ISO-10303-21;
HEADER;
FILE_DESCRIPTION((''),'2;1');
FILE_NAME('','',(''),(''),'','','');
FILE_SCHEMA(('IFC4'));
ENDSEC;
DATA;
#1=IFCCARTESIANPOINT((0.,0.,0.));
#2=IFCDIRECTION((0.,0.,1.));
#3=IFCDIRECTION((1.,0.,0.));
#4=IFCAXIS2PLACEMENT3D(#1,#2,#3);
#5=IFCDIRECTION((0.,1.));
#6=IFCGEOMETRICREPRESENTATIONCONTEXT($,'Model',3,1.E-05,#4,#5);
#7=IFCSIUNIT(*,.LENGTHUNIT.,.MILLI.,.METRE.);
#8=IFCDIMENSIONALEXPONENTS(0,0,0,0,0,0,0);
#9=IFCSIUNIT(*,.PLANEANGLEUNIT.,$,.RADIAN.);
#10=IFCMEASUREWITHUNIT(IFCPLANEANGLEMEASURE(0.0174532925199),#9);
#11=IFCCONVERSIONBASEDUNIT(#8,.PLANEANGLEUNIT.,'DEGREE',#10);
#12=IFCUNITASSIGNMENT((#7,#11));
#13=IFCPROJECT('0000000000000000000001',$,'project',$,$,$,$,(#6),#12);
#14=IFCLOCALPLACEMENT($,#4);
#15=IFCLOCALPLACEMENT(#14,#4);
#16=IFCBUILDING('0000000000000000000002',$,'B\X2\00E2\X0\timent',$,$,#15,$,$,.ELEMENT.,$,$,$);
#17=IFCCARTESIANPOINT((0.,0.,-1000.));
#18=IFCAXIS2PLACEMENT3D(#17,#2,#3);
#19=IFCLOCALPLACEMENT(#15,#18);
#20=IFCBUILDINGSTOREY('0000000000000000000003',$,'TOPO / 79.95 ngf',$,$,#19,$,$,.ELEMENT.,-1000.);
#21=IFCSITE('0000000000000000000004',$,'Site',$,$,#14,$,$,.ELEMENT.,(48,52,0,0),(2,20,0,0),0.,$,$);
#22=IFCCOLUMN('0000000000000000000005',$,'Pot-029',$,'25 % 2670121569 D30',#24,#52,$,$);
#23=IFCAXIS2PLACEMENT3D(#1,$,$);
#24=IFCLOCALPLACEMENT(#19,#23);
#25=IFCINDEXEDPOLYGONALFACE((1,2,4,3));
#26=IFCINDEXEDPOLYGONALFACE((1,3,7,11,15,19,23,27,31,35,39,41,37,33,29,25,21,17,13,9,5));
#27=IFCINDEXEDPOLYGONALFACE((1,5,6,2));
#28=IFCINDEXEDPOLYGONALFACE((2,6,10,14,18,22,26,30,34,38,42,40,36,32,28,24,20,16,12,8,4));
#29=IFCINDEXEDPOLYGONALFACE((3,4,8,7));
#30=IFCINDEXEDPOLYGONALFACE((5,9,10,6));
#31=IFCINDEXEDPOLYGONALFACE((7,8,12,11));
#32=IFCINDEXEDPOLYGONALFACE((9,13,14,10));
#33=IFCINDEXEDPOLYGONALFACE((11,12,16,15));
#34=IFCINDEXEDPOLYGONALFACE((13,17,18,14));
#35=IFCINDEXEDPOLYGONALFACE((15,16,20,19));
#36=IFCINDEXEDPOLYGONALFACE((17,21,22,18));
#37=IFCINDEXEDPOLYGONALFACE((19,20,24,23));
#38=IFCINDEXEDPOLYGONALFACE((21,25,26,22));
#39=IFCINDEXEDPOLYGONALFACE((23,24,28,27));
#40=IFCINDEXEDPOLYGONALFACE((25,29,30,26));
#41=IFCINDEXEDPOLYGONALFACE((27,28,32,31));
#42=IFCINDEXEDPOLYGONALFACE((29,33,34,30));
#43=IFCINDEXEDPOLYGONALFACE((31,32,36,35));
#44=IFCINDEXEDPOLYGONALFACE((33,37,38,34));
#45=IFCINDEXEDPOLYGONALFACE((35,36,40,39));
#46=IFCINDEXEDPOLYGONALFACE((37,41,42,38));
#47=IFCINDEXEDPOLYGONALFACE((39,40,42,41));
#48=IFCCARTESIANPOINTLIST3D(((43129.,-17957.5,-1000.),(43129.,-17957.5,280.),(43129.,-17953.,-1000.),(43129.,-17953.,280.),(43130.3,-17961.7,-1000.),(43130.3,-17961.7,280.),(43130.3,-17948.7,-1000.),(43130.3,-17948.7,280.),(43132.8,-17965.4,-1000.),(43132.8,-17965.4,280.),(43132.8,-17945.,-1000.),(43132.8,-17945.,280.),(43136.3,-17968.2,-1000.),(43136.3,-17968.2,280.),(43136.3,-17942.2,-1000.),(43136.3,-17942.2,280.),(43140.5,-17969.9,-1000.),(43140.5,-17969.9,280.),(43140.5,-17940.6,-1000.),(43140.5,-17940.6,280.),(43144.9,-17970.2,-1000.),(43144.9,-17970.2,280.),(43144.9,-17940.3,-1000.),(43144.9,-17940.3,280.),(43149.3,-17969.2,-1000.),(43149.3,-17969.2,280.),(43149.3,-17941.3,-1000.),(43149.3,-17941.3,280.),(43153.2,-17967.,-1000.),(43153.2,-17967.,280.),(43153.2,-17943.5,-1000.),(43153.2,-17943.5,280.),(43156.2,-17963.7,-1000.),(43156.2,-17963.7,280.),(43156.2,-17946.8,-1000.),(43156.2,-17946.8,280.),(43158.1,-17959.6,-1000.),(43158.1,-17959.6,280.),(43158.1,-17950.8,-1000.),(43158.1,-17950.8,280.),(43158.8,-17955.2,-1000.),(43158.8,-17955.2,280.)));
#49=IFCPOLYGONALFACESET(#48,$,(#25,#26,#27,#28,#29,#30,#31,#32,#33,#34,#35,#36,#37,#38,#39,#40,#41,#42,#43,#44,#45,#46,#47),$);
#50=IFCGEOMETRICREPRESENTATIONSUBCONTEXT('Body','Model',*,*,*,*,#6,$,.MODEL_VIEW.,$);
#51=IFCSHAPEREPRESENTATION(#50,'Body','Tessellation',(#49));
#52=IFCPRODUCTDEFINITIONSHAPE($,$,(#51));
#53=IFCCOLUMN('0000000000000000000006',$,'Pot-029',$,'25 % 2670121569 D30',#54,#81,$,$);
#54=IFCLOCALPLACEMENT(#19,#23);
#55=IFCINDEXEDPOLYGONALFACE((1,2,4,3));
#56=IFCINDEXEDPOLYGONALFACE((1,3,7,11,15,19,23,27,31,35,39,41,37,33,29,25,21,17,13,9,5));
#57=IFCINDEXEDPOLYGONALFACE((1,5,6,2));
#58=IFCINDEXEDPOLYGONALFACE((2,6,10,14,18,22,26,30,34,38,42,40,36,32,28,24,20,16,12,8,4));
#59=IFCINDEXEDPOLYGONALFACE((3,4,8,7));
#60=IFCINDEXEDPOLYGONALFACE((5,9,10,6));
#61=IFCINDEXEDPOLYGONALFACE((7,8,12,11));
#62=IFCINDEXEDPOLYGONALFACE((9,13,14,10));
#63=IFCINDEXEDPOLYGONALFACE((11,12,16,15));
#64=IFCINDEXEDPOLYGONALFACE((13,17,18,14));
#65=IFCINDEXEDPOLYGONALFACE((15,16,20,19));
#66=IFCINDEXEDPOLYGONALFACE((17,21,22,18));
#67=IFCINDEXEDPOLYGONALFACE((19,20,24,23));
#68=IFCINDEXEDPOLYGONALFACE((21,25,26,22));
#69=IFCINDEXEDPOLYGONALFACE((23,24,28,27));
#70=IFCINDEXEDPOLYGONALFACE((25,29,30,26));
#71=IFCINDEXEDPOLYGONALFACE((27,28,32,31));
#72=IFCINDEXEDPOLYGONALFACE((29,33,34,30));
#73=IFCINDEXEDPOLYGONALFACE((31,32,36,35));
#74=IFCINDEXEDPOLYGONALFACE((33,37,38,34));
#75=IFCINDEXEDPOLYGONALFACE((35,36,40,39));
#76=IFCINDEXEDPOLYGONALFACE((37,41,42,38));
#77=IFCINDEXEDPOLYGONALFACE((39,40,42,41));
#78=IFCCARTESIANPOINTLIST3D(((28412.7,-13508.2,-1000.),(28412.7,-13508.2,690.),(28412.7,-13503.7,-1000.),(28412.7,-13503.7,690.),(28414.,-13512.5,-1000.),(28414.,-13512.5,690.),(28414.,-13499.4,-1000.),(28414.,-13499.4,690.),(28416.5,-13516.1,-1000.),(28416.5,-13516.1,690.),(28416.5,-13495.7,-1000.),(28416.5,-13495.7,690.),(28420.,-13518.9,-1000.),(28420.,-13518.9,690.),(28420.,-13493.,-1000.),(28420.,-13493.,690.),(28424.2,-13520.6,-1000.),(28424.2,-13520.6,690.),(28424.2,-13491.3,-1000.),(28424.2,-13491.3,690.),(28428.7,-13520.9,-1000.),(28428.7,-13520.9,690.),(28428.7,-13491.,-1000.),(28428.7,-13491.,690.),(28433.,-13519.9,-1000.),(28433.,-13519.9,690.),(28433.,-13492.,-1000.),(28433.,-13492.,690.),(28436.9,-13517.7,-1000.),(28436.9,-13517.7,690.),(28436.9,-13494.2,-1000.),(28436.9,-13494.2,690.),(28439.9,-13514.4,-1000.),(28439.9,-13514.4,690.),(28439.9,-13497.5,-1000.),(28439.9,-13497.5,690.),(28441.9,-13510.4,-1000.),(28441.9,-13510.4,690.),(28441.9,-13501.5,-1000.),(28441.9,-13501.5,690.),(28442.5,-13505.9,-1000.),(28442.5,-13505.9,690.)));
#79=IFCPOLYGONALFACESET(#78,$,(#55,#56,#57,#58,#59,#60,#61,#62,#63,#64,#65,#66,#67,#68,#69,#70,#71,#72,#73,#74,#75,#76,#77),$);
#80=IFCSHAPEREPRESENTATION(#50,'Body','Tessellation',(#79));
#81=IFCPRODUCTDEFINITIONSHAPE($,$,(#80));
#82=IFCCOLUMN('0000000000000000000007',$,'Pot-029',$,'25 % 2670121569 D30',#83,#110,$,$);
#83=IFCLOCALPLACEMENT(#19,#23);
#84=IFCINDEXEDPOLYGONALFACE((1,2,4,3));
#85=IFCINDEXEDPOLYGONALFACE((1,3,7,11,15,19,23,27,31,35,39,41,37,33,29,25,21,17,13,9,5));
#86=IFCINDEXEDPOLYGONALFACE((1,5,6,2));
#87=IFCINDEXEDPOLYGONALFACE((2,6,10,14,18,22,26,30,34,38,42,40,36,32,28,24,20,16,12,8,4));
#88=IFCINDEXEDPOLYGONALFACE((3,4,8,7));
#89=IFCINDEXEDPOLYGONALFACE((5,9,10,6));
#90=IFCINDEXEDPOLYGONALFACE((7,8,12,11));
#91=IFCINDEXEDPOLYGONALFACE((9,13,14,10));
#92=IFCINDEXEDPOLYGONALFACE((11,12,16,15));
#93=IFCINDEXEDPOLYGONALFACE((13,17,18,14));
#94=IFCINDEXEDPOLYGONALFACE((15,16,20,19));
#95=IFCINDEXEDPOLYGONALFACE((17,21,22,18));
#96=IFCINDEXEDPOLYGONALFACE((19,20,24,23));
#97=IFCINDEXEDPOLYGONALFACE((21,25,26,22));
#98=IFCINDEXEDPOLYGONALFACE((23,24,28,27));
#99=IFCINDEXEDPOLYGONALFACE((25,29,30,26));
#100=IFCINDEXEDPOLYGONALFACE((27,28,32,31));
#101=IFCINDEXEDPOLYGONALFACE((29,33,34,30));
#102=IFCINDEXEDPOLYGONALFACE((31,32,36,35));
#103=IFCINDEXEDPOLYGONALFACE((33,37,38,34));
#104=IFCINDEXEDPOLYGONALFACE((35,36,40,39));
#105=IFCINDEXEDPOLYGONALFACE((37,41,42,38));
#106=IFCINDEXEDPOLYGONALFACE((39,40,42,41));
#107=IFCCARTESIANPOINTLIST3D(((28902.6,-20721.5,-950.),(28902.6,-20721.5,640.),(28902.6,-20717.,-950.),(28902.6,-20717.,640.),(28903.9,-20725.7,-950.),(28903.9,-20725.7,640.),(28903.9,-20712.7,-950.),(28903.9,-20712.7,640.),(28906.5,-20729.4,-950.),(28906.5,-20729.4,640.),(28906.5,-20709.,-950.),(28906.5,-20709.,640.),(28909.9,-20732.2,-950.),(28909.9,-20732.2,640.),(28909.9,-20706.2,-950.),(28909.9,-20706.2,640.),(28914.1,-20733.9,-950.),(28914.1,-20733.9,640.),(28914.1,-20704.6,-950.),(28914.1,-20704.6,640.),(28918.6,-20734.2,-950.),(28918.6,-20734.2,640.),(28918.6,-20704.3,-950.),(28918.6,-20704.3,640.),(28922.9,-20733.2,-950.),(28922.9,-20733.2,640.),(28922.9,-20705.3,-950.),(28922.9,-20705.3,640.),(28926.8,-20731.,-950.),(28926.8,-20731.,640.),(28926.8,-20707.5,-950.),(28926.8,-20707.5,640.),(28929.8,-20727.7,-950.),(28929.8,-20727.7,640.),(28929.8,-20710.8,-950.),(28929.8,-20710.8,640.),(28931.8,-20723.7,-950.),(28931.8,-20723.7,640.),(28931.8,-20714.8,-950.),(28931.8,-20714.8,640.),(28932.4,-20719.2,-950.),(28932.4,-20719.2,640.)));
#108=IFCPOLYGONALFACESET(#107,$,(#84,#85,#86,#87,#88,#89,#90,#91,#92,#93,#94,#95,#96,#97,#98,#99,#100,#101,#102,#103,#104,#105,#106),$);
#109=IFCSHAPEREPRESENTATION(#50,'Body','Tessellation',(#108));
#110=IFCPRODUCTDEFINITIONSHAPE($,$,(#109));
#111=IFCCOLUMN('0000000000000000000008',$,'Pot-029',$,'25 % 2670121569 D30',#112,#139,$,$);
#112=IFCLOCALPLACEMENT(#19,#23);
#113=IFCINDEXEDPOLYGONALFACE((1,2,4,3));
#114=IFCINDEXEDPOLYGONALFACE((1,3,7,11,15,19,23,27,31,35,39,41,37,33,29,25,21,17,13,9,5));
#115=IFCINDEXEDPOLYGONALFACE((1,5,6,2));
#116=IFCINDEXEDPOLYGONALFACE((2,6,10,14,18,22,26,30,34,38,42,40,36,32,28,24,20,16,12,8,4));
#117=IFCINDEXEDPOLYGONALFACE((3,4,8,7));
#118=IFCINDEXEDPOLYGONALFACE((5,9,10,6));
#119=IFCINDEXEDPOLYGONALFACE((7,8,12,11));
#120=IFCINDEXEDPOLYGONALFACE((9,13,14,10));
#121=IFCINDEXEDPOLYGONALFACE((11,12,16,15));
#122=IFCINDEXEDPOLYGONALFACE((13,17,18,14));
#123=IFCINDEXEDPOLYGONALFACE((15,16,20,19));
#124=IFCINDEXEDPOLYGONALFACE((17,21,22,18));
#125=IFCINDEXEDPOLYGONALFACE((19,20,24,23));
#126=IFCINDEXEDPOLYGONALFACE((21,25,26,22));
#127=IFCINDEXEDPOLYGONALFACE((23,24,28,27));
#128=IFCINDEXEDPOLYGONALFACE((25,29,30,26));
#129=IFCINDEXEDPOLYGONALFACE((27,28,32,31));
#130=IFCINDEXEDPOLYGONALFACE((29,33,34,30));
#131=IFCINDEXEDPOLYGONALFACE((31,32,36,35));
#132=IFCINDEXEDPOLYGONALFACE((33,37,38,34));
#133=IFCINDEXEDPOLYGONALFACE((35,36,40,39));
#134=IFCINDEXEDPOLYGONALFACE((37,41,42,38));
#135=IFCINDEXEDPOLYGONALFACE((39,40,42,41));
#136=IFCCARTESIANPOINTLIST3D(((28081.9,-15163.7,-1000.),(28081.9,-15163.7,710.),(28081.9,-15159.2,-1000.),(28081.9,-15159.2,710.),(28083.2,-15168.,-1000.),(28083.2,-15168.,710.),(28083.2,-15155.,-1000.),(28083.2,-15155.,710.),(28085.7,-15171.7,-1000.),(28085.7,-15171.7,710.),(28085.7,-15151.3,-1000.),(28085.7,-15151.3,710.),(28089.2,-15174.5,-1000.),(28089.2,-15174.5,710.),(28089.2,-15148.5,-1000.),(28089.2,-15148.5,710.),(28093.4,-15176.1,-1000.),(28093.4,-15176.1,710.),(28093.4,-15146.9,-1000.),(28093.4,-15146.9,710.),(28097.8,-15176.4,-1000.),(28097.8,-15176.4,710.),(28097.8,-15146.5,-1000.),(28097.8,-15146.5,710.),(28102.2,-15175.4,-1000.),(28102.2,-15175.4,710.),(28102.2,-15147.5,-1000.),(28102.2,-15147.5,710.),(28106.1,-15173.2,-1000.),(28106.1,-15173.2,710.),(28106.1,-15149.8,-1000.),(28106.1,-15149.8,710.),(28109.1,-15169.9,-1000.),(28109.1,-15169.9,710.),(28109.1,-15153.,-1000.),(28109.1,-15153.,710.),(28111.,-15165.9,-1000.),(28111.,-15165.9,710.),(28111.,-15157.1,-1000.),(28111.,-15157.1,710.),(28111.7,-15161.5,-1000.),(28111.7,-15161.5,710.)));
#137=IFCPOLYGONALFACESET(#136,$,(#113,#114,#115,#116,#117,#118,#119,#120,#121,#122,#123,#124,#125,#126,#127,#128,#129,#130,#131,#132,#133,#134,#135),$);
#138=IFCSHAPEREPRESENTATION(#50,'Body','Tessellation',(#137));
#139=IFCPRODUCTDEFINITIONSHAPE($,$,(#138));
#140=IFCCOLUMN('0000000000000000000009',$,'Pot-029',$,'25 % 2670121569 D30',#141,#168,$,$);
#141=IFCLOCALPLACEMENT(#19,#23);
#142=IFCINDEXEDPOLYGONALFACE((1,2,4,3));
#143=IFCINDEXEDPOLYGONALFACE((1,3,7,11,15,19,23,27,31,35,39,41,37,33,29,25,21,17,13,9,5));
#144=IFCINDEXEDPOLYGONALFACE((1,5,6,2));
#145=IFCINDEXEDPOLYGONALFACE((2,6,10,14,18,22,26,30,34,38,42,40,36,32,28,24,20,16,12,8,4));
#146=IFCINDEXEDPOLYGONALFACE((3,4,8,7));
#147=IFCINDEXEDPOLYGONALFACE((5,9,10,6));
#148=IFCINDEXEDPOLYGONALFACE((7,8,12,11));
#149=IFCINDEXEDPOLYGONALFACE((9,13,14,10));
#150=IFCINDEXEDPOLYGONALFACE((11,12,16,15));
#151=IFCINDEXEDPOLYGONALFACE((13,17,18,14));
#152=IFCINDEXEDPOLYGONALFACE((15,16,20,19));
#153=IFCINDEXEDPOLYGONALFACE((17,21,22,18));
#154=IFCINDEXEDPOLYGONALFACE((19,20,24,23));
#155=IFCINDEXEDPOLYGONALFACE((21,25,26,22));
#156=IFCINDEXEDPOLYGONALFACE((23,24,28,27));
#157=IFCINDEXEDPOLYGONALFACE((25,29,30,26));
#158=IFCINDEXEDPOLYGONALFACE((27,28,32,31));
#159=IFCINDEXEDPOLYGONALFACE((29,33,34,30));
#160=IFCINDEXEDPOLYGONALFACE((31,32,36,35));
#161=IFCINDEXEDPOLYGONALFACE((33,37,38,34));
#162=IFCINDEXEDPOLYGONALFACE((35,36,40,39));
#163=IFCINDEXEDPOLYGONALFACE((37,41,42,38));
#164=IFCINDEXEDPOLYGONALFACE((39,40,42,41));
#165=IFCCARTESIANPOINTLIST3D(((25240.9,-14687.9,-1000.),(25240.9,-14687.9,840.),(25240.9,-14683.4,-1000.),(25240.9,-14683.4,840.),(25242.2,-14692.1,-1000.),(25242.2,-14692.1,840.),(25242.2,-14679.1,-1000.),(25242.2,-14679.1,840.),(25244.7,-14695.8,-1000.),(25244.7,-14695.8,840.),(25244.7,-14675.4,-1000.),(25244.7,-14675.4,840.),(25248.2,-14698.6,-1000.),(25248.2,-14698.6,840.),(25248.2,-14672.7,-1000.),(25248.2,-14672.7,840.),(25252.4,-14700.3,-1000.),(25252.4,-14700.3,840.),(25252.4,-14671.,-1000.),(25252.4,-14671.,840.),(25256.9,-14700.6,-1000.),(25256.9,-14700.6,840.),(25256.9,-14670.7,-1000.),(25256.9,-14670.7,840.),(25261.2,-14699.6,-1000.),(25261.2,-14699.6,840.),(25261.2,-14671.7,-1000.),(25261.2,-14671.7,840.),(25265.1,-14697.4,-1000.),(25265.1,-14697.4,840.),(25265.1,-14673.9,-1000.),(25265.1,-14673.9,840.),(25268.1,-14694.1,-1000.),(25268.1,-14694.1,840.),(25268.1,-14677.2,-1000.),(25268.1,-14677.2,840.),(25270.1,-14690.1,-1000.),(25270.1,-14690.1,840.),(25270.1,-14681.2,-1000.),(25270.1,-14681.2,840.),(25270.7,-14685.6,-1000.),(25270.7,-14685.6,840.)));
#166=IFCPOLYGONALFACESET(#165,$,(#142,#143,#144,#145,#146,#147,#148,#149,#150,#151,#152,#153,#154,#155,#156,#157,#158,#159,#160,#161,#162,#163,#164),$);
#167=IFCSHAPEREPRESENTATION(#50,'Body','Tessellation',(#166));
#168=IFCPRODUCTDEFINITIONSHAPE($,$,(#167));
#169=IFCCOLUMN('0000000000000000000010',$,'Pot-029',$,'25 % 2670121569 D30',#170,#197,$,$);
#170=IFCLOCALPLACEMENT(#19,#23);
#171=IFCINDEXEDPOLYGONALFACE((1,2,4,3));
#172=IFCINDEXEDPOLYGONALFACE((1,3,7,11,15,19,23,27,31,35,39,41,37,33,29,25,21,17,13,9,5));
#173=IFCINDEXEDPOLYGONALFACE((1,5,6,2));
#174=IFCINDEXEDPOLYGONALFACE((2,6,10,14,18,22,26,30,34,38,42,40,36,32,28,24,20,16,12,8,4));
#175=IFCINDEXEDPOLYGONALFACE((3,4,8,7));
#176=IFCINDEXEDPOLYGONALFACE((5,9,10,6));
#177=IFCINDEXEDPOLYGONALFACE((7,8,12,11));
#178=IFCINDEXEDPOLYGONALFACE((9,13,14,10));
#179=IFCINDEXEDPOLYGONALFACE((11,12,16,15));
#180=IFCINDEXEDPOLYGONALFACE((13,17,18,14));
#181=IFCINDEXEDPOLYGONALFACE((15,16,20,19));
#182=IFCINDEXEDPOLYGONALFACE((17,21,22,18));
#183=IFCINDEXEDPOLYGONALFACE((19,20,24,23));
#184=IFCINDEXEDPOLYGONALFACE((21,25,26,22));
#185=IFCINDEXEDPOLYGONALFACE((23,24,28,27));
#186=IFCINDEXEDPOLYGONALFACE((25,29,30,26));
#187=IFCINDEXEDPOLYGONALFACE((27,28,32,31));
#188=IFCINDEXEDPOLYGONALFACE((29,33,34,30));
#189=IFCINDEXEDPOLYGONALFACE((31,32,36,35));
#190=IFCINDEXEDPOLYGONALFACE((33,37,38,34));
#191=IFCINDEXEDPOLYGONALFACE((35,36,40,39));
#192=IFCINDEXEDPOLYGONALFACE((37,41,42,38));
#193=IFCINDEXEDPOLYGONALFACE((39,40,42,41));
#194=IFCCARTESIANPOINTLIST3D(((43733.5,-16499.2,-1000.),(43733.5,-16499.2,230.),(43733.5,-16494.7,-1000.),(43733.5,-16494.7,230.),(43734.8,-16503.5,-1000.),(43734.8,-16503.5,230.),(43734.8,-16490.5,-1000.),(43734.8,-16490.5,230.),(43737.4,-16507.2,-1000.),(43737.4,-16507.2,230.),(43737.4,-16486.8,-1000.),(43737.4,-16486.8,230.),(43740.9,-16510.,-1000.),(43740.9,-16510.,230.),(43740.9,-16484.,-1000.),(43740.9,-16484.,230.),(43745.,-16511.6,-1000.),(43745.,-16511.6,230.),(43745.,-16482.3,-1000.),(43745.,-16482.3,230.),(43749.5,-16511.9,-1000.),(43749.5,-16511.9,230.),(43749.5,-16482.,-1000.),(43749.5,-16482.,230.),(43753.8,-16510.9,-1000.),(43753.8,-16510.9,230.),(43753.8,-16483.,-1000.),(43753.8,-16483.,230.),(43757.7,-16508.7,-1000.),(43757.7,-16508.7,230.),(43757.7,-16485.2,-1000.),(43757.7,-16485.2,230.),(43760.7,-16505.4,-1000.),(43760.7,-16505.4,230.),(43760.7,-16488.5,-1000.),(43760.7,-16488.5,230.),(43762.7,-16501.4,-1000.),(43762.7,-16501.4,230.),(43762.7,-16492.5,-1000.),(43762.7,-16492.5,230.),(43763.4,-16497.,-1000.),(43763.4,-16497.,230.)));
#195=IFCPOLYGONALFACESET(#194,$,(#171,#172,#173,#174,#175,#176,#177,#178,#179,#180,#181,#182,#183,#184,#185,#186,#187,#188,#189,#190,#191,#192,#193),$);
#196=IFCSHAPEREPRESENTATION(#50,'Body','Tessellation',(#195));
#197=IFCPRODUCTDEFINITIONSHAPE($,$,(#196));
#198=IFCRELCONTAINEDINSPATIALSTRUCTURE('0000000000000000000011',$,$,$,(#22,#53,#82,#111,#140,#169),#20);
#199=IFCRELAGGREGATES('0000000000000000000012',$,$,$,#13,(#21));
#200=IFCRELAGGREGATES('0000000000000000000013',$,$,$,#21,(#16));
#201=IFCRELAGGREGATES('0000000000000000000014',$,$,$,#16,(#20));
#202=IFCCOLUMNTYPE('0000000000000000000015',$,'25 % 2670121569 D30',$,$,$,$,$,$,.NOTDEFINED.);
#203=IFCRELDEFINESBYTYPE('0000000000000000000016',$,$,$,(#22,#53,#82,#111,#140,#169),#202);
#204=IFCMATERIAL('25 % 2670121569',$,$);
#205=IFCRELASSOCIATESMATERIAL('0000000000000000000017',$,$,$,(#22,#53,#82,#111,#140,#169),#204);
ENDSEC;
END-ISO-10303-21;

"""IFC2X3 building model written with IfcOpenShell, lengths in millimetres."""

from ifc_helpers import new_model, entity, si_unit, converted_unit, direction, frame, origin_with_axes, origin_2d_with_axis, place, context, subcontext, project, spatial, circle, extrude, material, type_object, element, save


model = new_model("IFC2X3")

# Units and contexts
model_context = context("Model", 3, precision=1e-05, world=origin_with_axes(), true_north=direction((0.0, 1.0)))
body_context = subcontext(model_context, "Body", "Model", "MODEL_VIEW")
ifc_project = project(units=[si_unit("LENGTHUNIT", "METRE", prefix="MILLI"), converted_unit("PLANEANGLEUNIT", "DEGREE", entity("IfcPlaneAngleMeasure", 0.0174532925199), si_unit("PLANEANGLEUNIT", "RADIAN"), dimensions=[0, 0, 0, 0, 0, 0, 0])], contexts=[model_context])

# Site, building, storey
site_placement = place(None, origin_with_axes())
site = spatial("IfcSite", under=ifc_project, at=site_placement, Name="Site", CompositionType="ELEMENT", RefLatitude=(48, 52, 0, 0), RefLongitude=(2, 20, 0, 0), RefElevation=0.0)
building_placement = place(site_placement, origin_with_axes())
building = spatial("IfcBuilding", under=site, at=building_placement, Name="Bâtiment", CompositionType="ELEMENT")
storey_placement = place(building_placement, frame((0.0, 0.0, -1000.0), z_axis=(0.0, 0.0, 1.0), x_axis=(1.0, 0.0, 0.0)))
storey = spatial("IfcBuildingStorey", under=building, at=storey_placement, Name="TOPO / 79.95 ngf", CompositionType="ELEMENT", Elevation=-1000.0)

# Columns
ifc_material_1 = material(Name="25 % 2670121569")
column_type_1 = type_object("IfcColumnType", Name="25 % 2670121569 D30", PredefinedType="NOTDEFINED")
column_1_placement = place(storey_placement, frame((43143.8, -17955.2, -1000.0), z_axis=(0.0, 0.0, 1.0), x_axis=(1.0, 0.0, 0.0)))
element("IfcColumn", 1, at=column_1_placement, inside=storey, type_object=column_type_1, material=ifc_material_1, Name="Pot-029", ObjectType="25 % 2670121569 D30", context=body_context, shape_type="SweptSolid", body=[
    extrude(circle(Radius=15.0, at=origin_2d_with_axis()), origin_with_axes(), (0.0, 0.0, 1.0), 1280.0),
])
column_2_placement = place(storey_placement, frame((28427.5, -13505.9, -1000.0), z_axis=(0.0, 0.0, 1.0), x_axis=(1.0, 0.0, 0.0)))
element("IfcColumn", 2, at=column_2_placement, inside=storey, type_object=column_type_1, material=ifc_material_1, Name="Pot-029", ObjectType="25 % 2670121569 D30", context=body_context, shape_type="SweptSolid", body=[
    extrude(circle(Radius=15.0, at=origin_2d_with_axis()), origin_with_axes(), (0.0, 0.0, 1.0), 1690.0),
])
column_3_placement = place(storey_placement, frame((28917.4, -20719.2, -950.0), z_axis=(0.0, 0.0, 1.0), x_axis=(1.0, 0.0, 0.0)))
element("IfcColumn", 3, at=column_3_placement, inside=storey, type_object=column_type_1, material=ifc_material_1, Name="Pot-029", ObjectType="25 % 2670121569 D30", context=body_context, shape_type="SweptSolid", body=[
    extrude(circle(Radius=15.0, at=origin_2d_with_axis()), origin_with_axes(), (0.0, 0.0, 1.0), 1590.0),
])
column_4_placement = place(storey_placement, frame((28096.7, -15161.5, -1000.0), z_axis=(0.0, 0.0, 1.0), x_axis=(1.0, 0.0, 0.0)))
element("IfcColumn", 4, at=column_4_placement, inside=storey, type_object=column_type_1, material=ifc_material_1, Name="Pot-029", ObjectType="25 % 2670121569 D30", context=body_context, shape_type="SweptSolid", body=[
    extrude(circle(Radius=15.0, at=origin_2d_with_axis()), origin_with_axes(), (0.0, 0.0, 1.0), 1710.0),
])
column_5_placement = place(storey_placement, frame((25255.7, -14685.6, -1000.0), z_axis=(0.0, 0.0, 1.0), x_axis=(1.0, 0.0, 0.0)))
element("IfcColumn", 5, at=column_5_placement, inside=storey, type_object=column_type_1, material=ifc_material_1, Name="Pot-029", ObjectType="25 % 2670121569 D30", context=body_context, shape_type="SweptSolid", body=[
    extrude(circle(Radius=15.0, at=origin_2d_with_axis()), origin_with_axes(), (0.0, 0.0, 1.0), 1840.0),
])
column_6_placement = place(storey_placement, frame((43748.4, -16497.0, -1000.0), z_axis=(0.0, 0.0, 1.0), x_axis=(1.0, 0.0, 0.0)))
element("IfcColumn", 6, at=column_6_placement, inside=storey, type_object=column_type_1, material=ifc_material_1, Name="Pot-029", ObjectType="25 % 2670121569 D30", context=body_context, shape_type="SweptSolid", body=[
    extrude(circle(Radius=15.0, at=origin_2d_with_axis()), origin_with_axes(), (0.0, 0.0, 1.0), 1230.0),
])

save(model, "model.ifc")
